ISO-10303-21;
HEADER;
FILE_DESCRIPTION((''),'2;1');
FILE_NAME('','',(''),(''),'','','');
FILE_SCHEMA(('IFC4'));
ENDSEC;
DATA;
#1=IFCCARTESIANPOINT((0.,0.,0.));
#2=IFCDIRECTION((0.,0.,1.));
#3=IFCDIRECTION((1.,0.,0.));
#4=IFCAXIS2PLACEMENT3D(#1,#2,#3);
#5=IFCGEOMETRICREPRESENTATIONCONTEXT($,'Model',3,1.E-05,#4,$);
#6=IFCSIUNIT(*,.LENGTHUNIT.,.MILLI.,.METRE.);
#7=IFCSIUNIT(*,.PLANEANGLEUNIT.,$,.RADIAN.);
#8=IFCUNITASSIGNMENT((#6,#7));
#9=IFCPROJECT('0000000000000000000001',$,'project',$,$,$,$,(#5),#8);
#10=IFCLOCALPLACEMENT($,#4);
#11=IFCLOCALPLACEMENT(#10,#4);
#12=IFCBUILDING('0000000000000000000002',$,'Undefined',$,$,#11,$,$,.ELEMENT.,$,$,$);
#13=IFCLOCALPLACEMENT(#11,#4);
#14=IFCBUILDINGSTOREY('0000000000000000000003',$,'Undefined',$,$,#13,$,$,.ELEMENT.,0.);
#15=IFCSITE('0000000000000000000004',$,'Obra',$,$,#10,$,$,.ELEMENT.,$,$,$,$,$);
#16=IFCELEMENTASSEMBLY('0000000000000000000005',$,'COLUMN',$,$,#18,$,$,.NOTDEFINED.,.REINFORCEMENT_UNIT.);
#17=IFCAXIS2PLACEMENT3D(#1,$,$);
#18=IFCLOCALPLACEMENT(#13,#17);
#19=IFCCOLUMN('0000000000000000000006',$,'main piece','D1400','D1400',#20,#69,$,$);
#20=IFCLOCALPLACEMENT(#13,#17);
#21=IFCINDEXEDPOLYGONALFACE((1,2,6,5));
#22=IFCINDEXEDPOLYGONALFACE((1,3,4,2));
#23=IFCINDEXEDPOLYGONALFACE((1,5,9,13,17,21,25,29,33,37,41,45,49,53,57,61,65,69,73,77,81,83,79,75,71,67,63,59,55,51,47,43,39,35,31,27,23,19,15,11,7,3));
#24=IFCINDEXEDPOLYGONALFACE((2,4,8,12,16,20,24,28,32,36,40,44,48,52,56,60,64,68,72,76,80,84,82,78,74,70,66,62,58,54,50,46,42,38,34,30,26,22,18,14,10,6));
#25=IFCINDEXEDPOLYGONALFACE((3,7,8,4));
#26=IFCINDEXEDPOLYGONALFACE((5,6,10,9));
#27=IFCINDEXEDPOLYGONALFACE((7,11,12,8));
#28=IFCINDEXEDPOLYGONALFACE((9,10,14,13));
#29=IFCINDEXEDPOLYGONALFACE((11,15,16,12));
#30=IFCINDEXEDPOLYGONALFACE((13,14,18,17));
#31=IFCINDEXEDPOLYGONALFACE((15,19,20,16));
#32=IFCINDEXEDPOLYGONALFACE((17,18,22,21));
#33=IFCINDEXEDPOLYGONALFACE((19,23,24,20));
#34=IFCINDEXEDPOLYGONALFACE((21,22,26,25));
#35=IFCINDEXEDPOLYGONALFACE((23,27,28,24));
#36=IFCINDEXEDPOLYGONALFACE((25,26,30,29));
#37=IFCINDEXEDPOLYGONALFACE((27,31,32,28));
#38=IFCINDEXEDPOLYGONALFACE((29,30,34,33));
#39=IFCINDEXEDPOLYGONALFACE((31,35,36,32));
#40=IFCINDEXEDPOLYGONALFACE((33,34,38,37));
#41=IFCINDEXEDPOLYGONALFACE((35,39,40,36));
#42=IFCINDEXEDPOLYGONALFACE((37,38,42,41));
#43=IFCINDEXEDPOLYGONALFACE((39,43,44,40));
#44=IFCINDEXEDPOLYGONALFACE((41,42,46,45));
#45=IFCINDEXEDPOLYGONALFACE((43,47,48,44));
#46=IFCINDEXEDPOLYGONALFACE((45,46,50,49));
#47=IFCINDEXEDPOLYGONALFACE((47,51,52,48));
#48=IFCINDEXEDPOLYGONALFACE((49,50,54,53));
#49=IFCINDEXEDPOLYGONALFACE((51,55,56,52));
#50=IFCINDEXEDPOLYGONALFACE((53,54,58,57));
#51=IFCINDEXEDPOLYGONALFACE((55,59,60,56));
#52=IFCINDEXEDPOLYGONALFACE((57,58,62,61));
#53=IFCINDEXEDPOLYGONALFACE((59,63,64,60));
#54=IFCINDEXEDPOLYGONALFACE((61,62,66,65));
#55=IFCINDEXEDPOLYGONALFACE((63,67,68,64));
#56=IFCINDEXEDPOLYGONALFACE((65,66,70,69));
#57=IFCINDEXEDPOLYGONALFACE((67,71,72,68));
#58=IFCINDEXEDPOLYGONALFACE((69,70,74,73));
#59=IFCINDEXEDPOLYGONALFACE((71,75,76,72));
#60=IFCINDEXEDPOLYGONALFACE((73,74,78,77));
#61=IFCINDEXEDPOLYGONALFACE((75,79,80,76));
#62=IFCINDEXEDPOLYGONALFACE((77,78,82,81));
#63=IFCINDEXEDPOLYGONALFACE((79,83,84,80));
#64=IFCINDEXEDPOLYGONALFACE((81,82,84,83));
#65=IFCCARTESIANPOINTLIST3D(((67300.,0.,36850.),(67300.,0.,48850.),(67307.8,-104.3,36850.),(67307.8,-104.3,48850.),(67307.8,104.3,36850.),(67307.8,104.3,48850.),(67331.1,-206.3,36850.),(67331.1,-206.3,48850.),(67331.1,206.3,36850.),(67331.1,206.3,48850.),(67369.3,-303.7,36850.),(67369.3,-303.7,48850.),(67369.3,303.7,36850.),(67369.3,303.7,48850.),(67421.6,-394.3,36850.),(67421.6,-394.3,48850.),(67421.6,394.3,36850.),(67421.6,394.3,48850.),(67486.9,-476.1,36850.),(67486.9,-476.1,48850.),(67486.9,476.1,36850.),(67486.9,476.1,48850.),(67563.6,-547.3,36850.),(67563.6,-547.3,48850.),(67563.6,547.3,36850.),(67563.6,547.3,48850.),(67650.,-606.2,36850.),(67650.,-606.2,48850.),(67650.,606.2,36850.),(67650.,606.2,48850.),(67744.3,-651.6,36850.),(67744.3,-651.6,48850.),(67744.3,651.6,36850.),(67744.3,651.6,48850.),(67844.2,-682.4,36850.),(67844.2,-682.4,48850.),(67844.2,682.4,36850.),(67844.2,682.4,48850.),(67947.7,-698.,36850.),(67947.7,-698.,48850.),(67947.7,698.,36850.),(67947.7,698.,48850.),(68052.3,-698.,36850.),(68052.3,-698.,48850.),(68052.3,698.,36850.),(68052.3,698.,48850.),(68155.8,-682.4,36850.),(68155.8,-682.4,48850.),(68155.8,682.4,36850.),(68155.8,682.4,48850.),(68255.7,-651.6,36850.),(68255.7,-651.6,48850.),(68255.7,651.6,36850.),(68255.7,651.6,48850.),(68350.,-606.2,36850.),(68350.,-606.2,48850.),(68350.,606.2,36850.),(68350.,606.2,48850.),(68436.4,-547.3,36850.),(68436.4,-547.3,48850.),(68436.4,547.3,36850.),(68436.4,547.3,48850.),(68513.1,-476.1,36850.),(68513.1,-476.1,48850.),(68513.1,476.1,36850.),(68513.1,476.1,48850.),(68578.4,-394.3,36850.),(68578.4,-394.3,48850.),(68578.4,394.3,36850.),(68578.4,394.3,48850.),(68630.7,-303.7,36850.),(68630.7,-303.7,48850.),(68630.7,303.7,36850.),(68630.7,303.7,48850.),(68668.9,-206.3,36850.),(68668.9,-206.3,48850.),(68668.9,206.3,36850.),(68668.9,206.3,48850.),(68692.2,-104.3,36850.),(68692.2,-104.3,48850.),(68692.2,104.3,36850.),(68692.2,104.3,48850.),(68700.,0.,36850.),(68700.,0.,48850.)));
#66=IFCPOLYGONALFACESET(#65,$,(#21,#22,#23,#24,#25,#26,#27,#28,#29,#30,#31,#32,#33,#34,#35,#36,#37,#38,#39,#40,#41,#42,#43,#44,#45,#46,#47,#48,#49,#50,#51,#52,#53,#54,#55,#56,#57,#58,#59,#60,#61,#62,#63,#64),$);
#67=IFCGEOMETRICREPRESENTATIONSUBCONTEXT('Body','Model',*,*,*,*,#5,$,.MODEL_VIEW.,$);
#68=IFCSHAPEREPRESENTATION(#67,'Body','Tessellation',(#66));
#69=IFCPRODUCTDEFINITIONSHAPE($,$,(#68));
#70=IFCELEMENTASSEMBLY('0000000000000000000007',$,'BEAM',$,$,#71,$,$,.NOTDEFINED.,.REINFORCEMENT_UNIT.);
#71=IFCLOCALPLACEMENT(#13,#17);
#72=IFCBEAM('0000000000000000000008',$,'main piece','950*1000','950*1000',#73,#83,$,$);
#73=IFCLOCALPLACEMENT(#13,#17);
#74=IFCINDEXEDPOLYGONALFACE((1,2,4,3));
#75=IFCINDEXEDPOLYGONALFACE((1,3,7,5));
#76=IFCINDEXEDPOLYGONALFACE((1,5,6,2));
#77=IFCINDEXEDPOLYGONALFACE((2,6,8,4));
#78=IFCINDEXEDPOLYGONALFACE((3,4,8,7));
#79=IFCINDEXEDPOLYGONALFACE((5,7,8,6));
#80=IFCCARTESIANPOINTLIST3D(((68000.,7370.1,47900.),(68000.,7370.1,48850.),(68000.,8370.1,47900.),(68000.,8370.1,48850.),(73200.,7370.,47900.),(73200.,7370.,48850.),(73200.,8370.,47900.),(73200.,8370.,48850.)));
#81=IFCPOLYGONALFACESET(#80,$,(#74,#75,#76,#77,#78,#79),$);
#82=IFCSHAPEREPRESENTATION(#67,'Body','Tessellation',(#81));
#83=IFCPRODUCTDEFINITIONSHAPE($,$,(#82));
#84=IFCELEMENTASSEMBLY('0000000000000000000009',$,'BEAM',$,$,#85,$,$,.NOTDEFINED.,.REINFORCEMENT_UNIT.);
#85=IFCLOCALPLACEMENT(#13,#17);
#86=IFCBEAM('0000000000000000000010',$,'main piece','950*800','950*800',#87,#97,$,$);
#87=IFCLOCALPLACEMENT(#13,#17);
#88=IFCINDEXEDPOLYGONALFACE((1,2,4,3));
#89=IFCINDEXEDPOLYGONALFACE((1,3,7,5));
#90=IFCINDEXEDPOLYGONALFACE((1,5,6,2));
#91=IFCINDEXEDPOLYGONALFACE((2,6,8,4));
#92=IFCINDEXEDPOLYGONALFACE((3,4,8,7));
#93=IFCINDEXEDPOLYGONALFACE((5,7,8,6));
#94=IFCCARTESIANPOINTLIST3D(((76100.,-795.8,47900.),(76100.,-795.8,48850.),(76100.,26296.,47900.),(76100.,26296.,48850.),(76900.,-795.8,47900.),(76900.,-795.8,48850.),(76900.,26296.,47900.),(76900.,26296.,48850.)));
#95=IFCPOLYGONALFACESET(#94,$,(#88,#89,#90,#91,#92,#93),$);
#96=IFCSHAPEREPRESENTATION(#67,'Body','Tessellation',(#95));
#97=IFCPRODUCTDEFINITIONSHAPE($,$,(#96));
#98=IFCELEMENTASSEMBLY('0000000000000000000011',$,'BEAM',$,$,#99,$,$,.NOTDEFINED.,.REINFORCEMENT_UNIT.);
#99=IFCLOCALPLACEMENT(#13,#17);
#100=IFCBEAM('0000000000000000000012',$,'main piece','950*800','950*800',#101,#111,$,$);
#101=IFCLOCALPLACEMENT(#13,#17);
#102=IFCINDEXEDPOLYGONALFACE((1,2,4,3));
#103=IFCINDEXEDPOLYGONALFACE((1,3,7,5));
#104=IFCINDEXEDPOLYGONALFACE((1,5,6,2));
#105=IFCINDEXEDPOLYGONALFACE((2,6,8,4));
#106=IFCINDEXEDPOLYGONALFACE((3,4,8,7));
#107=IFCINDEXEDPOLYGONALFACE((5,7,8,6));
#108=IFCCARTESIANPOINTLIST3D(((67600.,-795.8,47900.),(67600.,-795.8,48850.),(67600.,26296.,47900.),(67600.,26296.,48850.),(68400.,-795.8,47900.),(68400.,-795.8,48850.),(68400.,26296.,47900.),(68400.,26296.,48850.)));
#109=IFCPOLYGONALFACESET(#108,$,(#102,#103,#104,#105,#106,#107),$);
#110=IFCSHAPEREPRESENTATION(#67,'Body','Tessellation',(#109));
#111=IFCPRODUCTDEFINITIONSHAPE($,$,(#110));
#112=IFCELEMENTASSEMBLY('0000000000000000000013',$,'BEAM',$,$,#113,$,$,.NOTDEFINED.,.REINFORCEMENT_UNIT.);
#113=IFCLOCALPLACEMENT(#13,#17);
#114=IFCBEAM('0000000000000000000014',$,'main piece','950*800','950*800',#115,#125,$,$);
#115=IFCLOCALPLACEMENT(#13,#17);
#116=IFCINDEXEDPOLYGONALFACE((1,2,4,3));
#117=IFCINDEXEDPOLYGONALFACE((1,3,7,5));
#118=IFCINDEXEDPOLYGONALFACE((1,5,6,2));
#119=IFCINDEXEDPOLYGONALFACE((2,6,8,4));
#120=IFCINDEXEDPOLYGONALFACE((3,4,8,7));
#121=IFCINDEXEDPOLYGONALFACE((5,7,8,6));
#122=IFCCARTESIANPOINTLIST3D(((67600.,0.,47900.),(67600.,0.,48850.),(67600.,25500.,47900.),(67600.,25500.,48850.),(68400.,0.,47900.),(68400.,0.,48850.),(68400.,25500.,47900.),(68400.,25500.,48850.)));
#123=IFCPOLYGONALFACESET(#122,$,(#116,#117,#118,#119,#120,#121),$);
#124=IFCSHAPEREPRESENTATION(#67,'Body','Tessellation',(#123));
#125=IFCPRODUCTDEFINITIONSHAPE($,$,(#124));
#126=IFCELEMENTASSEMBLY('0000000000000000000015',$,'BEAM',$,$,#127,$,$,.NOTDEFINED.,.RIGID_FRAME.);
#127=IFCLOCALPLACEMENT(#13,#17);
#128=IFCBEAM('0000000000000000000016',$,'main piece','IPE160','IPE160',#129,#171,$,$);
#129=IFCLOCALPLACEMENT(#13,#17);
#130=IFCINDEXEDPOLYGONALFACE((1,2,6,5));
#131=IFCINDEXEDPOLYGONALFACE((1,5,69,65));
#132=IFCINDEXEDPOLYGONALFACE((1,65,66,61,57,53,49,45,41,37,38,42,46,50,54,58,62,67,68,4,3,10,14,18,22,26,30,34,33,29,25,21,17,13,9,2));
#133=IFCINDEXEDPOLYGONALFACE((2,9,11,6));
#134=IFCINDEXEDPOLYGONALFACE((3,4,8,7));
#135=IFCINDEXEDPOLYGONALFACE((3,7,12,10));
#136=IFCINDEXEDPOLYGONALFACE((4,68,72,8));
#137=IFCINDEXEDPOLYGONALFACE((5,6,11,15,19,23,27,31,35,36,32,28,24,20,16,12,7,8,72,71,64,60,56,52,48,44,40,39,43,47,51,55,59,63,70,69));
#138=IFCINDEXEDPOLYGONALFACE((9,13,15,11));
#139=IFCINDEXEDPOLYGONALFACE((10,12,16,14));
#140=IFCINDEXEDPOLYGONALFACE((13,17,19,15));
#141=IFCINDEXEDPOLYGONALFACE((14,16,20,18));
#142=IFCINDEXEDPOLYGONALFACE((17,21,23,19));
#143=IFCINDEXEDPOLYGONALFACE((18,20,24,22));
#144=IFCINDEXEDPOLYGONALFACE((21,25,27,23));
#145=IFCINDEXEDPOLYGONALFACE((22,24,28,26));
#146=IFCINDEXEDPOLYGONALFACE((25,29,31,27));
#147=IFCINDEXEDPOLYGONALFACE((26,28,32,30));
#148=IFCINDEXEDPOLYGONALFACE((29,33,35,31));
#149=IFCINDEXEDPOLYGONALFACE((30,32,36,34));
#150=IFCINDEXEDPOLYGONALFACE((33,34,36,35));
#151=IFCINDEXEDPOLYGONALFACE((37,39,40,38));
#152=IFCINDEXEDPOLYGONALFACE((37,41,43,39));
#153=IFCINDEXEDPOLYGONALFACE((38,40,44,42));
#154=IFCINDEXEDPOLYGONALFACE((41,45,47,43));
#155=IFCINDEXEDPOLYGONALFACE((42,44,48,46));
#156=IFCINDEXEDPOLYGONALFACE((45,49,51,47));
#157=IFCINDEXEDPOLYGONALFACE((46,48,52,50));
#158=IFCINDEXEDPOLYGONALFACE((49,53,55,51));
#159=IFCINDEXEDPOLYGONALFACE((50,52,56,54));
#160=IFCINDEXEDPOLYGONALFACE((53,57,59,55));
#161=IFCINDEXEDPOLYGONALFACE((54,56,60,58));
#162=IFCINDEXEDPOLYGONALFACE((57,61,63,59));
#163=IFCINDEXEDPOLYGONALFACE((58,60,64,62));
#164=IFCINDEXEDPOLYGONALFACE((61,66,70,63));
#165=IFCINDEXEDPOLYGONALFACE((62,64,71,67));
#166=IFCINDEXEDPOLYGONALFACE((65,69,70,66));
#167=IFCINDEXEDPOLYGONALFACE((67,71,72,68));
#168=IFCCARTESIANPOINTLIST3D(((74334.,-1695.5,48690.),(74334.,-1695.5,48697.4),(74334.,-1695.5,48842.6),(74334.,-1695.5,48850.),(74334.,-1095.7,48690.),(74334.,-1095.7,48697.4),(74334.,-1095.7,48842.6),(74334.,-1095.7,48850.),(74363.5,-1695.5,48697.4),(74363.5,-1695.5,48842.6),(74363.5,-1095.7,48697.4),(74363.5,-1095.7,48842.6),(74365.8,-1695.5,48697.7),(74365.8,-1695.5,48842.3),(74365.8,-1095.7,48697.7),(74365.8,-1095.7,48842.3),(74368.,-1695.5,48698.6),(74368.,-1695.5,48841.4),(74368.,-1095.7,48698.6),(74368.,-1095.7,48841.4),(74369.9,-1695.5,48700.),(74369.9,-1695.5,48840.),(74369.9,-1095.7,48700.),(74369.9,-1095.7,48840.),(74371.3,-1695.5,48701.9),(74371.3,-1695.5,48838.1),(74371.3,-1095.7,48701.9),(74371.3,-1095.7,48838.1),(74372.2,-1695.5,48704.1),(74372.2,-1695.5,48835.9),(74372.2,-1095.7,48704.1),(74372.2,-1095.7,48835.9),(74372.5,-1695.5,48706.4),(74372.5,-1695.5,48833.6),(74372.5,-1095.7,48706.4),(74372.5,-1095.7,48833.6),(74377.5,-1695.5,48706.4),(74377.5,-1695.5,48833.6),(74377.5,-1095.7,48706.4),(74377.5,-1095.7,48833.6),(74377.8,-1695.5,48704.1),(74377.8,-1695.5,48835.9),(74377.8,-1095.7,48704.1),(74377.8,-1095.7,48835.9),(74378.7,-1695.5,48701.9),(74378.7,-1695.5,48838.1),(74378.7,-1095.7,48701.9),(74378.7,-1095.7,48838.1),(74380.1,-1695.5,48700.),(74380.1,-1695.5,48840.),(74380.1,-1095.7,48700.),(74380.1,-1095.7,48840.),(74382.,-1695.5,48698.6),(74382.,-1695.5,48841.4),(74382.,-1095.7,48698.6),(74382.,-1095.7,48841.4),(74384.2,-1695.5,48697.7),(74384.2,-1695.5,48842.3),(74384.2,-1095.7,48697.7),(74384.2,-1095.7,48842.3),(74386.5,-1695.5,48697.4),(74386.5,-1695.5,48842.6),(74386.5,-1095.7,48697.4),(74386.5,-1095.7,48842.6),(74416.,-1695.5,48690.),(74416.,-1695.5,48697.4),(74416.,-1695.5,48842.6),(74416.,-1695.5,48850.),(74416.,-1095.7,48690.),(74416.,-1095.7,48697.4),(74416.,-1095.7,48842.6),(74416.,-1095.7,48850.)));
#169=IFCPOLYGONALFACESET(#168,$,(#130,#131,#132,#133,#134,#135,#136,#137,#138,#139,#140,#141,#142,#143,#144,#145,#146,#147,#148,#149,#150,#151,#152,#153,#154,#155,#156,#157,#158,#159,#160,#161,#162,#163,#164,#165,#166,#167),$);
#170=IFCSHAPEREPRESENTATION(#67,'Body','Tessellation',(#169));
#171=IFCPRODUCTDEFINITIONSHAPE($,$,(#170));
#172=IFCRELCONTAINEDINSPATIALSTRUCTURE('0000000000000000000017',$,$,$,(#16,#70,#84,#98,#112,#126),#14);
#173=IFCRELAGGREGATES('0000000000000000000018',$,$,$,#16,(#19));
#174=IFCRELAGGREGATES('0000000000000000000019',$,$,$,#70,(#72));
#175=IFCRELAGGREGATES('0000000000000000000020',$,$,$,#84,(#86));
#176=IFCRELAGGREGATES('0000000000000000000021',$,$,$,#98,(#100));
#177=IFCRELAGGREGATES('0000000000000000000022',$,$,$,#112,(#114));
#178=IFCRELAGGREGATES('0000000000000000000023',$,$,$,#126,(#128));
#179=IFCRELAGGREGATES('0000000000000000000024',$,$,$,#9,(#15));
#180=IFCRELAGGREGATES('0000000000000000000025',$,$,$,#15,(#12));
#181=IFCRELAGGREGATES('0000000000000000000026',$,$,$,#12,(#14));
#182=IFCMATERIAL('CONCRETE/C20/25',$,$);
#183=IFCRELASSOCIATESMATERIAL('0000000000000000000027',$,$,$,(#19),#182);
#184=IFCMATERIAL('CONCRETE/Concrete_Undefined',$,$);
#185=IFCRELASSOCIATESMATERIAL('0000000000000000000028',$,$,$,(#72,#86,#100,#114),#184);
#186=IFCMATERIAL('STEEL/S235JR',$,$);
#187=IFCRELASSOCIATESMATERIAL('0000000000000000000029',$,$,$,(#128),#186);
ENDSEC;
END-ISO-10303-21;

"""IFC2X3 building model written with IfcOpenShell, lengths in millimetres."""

from ifc_helpers import new_model, si_unit, frame, origin_with_axes, origin_2d_with_axis, place, context, subcontext, project, spatial, rectangle, circle, i_section, extrude, material, element, aggregate, save


model = new_model("IFC2X3")

# Units and contexts
model_context = context("Model", 3, precision=1e-05, world=origin_with_axes())
body_context = subcontext(model_context, "Body", "Model", "MODEL_VIEW")
ifc_project = project(units=[si_unit("LENGTHUNIT", "METRE", prefix="MILLI"), si_unit("PLANEANGLEUNIT", "RADIAN")], contexts=[model_context])

# Site, building, storey
site_placement = place(None, origin_with_axes())
site = spatial("IfcSite", under=ifc_project, at=site_placement, Name="Obra", CompositionType="ELEMENT")
building_placement = place(site_placement, origin_with_axes())
building = spatial("IfcBuilding", under=site, at=building_placement, Name="Undefined", CompositionType="ELEMENT")
storey_placement = place(building_placement, origin_with_axes())
storey = spatial("IfcBuildingStorey", under=building, at=storey_placement, Name="Undefined", CompositionType="ELEMENT", Elevation=0.0)

# Element assembly, column
ifc_material_1 = material(Name="STEEL/S235JR")
ifc_material_2 = material(Name="CONCRETE/C20/25")
assembly_1_placement = place(storey_placement, origin_with_axes())
assembly_1 = element("IfcElementAssembly", 1, at=assembly_1_placement, inside=storey, Name="COLUMN", AssemblyPlace="NOTDEFINED", PredefinedType="REINFORCEMENT_UNIT")
column_1_placement = place(assembly_1_placement, frame((68000.0, 0.0, 36850.0), z_axis=(0.0, 0.0, 1.0), x_axis=(0.0, 1.0, 0.0)))
column_1 = element("IfcColumn", 2, at=column_1_placement, material=ifc_material_2, Name="main piece", Description="D1400", ObjectType="D1400", context=body_context, shape_type="SweptSolid", body=[
    extrude(circle(Radius=700.0, at=origin_2d_with_axis()), frame((0.0, 0.0, 12000.0), z_axis=(0.0, 0.0, -1.0), x_axis=(0.0, 1.0, 0.0)), (0.0, 0.0, 1.0), 12000.0),
])
aggregate(assembly_1, [column_1])

# Element assemblies, beams
assembly_2_placement = place(storey_placement, origin_with_axes())
assembly_2 = element("IfcElementAssembly", 3, at=assembly_2_placement, inside=storey, Name="BEAM", AssemblyPlace="NOTDEFINED", PredefinedType="REINFORCEMENT_UNIT")
ifc_material_3 = material(Name="CONCRETE/Concrete_Undefined")
beam_1_placement = place(assembly_2_placement, frame((68000.0, 7870.1, 48375.0), z_axis=(0.0, 0.0, 1.0), x_axis=(1.0, -0.000019, 0.0)))
beam_1 = element("IfcBeam", 4, at=beam_1_placement, material=ifc_material_3, Name="main piece", Description="950*1000", ObjectType="950*1000", context=body_context, shape_type="SweptSolid", body=[
    extrude(rectangle(XDim=1000.0, YDim=950.0, at=origin_2d_with_axis()), frame((5200.0, 0.0, 0.0), z_axis=(-1.0, 0.0, 0.0), x_axis=(0.0, -1.0, 0.0)), (0.0, 0.0, 1.0), 5200.0),
])
aggregate(assembly_2, [beam_1])
assembly_3_placement = place(storey_placement, origin_with_axes())
assembly_3 = element("IfcElementAssembly", 5, at=assembly_3_placement, inside=storey, Name="BEAM", AssemblyPlace="NOTDEFINED", PredefinedType="REINFORCEMENT_UNIT")
beam_2_placement = place(assembly_3_placement, frame((76500.0, -795.8, 48375.0), z_axis=(0.0, 0.0, 1.0), x_axis=(0.0, 1.0, 0.0)))
beam_2 = element("IfcBeam", 6, at=beam_2_placement, material=ifc_material_3, Name="main piece", Description="950*800", ObjectType="950*800", context=body_context, shape_type="SweptSolid", body=[
    extrude(rectangle(XDim=800.0, YDim=950.0, at=origin_2d_with_axis()), frame((27091.8, 0.0, 0.0), z_axis=(-1.0, 0.0, 0.0), x_axis=(0.0, -1.0, 0.0)), (0.0, 0.0, 1.0), 27091.8),
])
aggregate(assembly_3, [beam_2])
assembly_4_placement = place(storey_placement, origin_with_axes())
assembly_4 = element("IfcElementAssembly", 7, at=assembly_4_placement, inside=storey, Name="BEAM", AssemblyPlace="NOTDEFINED", PredefinedType="REINFORCEMENT_UNIT")
beam_3_placement = place(assembly_4_placement, frame((68000.0, -795.8, 48375.0), z_axis=(0.0, 0.0, 1.0), x_axis=(0.0, 1.0, 0.0)))
beam_3 = element("IfcBeam", 8, at=beam_3_placement, material=ifc_material_3, Name="main piece", Description="950*800", ObjectType="950*800", context=body_context, shape_type="SweptSolid", body=[
    extrude(rectangle(XDim=800.0, YDim=950.0, at=origin_2d_with_axis()), frame((27091.8, 0.0, 0.0), z_axis=(-1.0, 0.0, 0.0), x_axis=(0.0, -1.0, 0.0)), (0.0, 0.0, 1.0), 27091.8),
])
aggregate(assembly_4, [beam_3])
assembly_5_placement = place(storey_placement, origin_with_axes())
assembly_5 = element("IfcElementAssembly", 9, at=assembly_5_placement, inside=storey, Name="BEAM", AssemblyPlace="NOTDEFINED", PredefinedType="REINFORCEMENT_UNIT")
beam_4_placement = place(assembly_5_placement, frame((68000.0, 0.0, 48375.0), z_axis=(0.0, 0.0, 1.0), x_axis=(0.0, 1.0, 0.0)))
beam_4 = element("IfcBeam", 10, at=beam_4_placement, material=ifc_material_3, Name="main piece", Description="950*800", ObjectType="950*800", context=body_context, shape_type="SweptSolid", body=[
    extrude(rectangle(XDim=800.0, YDim=950.0, at=origin_2d_with_axis()), frame((25500.0, 0.0, 0.0), z_axis=(-1.0, 0.0, 0.0), x_axis=(0.0, -1.0, 0.0)), (0.0, 0.0, 1.0), 25500.0),
])
aggregate(assembly_5, [beam_4])
assembly_6_placement = place(storey_placement, origin_with_axes())
assembly_6 = element("IfcElementAssembly", 11, at=assembly_6_placement, inside=storey, Name="BEAM", AssemblyPlace="NOTDEFINED", PredefinedType="RIGID_FRAME")
beam_5_placement = place(assembly_6_placement, frame((74375.0, -1095.7, 48770.0), z_axis=(0.0, 0.0, 1.0), x_axis=(0.0, -1.0, 0.0)))
beam_5 = element("IfcBeam", 12, at=beam_5_placement, material=ifc_material_1, Name="main piece", Description="IPE160", ObjectType="IPE160", context=body_context, shape_type="SweptSolid", body=[
    extrude(i_section(OverallWidth=82.0, OverallDepth=160.0, WebThickness=5.0, FlangeThickness=7.4, FilletRadius=9.0, at=origin_2d_with_axis()), frame((599.8, 0.0, 0.0), z_axis=(-1.0, 0.0, 0.0), x_axis=(0.0, -1.0, 0.0)), (0.0, 0.0, 1.0), 599.8),
])
aggregate(assembly_6, [beam_5])

save(model, "model.ifc")
